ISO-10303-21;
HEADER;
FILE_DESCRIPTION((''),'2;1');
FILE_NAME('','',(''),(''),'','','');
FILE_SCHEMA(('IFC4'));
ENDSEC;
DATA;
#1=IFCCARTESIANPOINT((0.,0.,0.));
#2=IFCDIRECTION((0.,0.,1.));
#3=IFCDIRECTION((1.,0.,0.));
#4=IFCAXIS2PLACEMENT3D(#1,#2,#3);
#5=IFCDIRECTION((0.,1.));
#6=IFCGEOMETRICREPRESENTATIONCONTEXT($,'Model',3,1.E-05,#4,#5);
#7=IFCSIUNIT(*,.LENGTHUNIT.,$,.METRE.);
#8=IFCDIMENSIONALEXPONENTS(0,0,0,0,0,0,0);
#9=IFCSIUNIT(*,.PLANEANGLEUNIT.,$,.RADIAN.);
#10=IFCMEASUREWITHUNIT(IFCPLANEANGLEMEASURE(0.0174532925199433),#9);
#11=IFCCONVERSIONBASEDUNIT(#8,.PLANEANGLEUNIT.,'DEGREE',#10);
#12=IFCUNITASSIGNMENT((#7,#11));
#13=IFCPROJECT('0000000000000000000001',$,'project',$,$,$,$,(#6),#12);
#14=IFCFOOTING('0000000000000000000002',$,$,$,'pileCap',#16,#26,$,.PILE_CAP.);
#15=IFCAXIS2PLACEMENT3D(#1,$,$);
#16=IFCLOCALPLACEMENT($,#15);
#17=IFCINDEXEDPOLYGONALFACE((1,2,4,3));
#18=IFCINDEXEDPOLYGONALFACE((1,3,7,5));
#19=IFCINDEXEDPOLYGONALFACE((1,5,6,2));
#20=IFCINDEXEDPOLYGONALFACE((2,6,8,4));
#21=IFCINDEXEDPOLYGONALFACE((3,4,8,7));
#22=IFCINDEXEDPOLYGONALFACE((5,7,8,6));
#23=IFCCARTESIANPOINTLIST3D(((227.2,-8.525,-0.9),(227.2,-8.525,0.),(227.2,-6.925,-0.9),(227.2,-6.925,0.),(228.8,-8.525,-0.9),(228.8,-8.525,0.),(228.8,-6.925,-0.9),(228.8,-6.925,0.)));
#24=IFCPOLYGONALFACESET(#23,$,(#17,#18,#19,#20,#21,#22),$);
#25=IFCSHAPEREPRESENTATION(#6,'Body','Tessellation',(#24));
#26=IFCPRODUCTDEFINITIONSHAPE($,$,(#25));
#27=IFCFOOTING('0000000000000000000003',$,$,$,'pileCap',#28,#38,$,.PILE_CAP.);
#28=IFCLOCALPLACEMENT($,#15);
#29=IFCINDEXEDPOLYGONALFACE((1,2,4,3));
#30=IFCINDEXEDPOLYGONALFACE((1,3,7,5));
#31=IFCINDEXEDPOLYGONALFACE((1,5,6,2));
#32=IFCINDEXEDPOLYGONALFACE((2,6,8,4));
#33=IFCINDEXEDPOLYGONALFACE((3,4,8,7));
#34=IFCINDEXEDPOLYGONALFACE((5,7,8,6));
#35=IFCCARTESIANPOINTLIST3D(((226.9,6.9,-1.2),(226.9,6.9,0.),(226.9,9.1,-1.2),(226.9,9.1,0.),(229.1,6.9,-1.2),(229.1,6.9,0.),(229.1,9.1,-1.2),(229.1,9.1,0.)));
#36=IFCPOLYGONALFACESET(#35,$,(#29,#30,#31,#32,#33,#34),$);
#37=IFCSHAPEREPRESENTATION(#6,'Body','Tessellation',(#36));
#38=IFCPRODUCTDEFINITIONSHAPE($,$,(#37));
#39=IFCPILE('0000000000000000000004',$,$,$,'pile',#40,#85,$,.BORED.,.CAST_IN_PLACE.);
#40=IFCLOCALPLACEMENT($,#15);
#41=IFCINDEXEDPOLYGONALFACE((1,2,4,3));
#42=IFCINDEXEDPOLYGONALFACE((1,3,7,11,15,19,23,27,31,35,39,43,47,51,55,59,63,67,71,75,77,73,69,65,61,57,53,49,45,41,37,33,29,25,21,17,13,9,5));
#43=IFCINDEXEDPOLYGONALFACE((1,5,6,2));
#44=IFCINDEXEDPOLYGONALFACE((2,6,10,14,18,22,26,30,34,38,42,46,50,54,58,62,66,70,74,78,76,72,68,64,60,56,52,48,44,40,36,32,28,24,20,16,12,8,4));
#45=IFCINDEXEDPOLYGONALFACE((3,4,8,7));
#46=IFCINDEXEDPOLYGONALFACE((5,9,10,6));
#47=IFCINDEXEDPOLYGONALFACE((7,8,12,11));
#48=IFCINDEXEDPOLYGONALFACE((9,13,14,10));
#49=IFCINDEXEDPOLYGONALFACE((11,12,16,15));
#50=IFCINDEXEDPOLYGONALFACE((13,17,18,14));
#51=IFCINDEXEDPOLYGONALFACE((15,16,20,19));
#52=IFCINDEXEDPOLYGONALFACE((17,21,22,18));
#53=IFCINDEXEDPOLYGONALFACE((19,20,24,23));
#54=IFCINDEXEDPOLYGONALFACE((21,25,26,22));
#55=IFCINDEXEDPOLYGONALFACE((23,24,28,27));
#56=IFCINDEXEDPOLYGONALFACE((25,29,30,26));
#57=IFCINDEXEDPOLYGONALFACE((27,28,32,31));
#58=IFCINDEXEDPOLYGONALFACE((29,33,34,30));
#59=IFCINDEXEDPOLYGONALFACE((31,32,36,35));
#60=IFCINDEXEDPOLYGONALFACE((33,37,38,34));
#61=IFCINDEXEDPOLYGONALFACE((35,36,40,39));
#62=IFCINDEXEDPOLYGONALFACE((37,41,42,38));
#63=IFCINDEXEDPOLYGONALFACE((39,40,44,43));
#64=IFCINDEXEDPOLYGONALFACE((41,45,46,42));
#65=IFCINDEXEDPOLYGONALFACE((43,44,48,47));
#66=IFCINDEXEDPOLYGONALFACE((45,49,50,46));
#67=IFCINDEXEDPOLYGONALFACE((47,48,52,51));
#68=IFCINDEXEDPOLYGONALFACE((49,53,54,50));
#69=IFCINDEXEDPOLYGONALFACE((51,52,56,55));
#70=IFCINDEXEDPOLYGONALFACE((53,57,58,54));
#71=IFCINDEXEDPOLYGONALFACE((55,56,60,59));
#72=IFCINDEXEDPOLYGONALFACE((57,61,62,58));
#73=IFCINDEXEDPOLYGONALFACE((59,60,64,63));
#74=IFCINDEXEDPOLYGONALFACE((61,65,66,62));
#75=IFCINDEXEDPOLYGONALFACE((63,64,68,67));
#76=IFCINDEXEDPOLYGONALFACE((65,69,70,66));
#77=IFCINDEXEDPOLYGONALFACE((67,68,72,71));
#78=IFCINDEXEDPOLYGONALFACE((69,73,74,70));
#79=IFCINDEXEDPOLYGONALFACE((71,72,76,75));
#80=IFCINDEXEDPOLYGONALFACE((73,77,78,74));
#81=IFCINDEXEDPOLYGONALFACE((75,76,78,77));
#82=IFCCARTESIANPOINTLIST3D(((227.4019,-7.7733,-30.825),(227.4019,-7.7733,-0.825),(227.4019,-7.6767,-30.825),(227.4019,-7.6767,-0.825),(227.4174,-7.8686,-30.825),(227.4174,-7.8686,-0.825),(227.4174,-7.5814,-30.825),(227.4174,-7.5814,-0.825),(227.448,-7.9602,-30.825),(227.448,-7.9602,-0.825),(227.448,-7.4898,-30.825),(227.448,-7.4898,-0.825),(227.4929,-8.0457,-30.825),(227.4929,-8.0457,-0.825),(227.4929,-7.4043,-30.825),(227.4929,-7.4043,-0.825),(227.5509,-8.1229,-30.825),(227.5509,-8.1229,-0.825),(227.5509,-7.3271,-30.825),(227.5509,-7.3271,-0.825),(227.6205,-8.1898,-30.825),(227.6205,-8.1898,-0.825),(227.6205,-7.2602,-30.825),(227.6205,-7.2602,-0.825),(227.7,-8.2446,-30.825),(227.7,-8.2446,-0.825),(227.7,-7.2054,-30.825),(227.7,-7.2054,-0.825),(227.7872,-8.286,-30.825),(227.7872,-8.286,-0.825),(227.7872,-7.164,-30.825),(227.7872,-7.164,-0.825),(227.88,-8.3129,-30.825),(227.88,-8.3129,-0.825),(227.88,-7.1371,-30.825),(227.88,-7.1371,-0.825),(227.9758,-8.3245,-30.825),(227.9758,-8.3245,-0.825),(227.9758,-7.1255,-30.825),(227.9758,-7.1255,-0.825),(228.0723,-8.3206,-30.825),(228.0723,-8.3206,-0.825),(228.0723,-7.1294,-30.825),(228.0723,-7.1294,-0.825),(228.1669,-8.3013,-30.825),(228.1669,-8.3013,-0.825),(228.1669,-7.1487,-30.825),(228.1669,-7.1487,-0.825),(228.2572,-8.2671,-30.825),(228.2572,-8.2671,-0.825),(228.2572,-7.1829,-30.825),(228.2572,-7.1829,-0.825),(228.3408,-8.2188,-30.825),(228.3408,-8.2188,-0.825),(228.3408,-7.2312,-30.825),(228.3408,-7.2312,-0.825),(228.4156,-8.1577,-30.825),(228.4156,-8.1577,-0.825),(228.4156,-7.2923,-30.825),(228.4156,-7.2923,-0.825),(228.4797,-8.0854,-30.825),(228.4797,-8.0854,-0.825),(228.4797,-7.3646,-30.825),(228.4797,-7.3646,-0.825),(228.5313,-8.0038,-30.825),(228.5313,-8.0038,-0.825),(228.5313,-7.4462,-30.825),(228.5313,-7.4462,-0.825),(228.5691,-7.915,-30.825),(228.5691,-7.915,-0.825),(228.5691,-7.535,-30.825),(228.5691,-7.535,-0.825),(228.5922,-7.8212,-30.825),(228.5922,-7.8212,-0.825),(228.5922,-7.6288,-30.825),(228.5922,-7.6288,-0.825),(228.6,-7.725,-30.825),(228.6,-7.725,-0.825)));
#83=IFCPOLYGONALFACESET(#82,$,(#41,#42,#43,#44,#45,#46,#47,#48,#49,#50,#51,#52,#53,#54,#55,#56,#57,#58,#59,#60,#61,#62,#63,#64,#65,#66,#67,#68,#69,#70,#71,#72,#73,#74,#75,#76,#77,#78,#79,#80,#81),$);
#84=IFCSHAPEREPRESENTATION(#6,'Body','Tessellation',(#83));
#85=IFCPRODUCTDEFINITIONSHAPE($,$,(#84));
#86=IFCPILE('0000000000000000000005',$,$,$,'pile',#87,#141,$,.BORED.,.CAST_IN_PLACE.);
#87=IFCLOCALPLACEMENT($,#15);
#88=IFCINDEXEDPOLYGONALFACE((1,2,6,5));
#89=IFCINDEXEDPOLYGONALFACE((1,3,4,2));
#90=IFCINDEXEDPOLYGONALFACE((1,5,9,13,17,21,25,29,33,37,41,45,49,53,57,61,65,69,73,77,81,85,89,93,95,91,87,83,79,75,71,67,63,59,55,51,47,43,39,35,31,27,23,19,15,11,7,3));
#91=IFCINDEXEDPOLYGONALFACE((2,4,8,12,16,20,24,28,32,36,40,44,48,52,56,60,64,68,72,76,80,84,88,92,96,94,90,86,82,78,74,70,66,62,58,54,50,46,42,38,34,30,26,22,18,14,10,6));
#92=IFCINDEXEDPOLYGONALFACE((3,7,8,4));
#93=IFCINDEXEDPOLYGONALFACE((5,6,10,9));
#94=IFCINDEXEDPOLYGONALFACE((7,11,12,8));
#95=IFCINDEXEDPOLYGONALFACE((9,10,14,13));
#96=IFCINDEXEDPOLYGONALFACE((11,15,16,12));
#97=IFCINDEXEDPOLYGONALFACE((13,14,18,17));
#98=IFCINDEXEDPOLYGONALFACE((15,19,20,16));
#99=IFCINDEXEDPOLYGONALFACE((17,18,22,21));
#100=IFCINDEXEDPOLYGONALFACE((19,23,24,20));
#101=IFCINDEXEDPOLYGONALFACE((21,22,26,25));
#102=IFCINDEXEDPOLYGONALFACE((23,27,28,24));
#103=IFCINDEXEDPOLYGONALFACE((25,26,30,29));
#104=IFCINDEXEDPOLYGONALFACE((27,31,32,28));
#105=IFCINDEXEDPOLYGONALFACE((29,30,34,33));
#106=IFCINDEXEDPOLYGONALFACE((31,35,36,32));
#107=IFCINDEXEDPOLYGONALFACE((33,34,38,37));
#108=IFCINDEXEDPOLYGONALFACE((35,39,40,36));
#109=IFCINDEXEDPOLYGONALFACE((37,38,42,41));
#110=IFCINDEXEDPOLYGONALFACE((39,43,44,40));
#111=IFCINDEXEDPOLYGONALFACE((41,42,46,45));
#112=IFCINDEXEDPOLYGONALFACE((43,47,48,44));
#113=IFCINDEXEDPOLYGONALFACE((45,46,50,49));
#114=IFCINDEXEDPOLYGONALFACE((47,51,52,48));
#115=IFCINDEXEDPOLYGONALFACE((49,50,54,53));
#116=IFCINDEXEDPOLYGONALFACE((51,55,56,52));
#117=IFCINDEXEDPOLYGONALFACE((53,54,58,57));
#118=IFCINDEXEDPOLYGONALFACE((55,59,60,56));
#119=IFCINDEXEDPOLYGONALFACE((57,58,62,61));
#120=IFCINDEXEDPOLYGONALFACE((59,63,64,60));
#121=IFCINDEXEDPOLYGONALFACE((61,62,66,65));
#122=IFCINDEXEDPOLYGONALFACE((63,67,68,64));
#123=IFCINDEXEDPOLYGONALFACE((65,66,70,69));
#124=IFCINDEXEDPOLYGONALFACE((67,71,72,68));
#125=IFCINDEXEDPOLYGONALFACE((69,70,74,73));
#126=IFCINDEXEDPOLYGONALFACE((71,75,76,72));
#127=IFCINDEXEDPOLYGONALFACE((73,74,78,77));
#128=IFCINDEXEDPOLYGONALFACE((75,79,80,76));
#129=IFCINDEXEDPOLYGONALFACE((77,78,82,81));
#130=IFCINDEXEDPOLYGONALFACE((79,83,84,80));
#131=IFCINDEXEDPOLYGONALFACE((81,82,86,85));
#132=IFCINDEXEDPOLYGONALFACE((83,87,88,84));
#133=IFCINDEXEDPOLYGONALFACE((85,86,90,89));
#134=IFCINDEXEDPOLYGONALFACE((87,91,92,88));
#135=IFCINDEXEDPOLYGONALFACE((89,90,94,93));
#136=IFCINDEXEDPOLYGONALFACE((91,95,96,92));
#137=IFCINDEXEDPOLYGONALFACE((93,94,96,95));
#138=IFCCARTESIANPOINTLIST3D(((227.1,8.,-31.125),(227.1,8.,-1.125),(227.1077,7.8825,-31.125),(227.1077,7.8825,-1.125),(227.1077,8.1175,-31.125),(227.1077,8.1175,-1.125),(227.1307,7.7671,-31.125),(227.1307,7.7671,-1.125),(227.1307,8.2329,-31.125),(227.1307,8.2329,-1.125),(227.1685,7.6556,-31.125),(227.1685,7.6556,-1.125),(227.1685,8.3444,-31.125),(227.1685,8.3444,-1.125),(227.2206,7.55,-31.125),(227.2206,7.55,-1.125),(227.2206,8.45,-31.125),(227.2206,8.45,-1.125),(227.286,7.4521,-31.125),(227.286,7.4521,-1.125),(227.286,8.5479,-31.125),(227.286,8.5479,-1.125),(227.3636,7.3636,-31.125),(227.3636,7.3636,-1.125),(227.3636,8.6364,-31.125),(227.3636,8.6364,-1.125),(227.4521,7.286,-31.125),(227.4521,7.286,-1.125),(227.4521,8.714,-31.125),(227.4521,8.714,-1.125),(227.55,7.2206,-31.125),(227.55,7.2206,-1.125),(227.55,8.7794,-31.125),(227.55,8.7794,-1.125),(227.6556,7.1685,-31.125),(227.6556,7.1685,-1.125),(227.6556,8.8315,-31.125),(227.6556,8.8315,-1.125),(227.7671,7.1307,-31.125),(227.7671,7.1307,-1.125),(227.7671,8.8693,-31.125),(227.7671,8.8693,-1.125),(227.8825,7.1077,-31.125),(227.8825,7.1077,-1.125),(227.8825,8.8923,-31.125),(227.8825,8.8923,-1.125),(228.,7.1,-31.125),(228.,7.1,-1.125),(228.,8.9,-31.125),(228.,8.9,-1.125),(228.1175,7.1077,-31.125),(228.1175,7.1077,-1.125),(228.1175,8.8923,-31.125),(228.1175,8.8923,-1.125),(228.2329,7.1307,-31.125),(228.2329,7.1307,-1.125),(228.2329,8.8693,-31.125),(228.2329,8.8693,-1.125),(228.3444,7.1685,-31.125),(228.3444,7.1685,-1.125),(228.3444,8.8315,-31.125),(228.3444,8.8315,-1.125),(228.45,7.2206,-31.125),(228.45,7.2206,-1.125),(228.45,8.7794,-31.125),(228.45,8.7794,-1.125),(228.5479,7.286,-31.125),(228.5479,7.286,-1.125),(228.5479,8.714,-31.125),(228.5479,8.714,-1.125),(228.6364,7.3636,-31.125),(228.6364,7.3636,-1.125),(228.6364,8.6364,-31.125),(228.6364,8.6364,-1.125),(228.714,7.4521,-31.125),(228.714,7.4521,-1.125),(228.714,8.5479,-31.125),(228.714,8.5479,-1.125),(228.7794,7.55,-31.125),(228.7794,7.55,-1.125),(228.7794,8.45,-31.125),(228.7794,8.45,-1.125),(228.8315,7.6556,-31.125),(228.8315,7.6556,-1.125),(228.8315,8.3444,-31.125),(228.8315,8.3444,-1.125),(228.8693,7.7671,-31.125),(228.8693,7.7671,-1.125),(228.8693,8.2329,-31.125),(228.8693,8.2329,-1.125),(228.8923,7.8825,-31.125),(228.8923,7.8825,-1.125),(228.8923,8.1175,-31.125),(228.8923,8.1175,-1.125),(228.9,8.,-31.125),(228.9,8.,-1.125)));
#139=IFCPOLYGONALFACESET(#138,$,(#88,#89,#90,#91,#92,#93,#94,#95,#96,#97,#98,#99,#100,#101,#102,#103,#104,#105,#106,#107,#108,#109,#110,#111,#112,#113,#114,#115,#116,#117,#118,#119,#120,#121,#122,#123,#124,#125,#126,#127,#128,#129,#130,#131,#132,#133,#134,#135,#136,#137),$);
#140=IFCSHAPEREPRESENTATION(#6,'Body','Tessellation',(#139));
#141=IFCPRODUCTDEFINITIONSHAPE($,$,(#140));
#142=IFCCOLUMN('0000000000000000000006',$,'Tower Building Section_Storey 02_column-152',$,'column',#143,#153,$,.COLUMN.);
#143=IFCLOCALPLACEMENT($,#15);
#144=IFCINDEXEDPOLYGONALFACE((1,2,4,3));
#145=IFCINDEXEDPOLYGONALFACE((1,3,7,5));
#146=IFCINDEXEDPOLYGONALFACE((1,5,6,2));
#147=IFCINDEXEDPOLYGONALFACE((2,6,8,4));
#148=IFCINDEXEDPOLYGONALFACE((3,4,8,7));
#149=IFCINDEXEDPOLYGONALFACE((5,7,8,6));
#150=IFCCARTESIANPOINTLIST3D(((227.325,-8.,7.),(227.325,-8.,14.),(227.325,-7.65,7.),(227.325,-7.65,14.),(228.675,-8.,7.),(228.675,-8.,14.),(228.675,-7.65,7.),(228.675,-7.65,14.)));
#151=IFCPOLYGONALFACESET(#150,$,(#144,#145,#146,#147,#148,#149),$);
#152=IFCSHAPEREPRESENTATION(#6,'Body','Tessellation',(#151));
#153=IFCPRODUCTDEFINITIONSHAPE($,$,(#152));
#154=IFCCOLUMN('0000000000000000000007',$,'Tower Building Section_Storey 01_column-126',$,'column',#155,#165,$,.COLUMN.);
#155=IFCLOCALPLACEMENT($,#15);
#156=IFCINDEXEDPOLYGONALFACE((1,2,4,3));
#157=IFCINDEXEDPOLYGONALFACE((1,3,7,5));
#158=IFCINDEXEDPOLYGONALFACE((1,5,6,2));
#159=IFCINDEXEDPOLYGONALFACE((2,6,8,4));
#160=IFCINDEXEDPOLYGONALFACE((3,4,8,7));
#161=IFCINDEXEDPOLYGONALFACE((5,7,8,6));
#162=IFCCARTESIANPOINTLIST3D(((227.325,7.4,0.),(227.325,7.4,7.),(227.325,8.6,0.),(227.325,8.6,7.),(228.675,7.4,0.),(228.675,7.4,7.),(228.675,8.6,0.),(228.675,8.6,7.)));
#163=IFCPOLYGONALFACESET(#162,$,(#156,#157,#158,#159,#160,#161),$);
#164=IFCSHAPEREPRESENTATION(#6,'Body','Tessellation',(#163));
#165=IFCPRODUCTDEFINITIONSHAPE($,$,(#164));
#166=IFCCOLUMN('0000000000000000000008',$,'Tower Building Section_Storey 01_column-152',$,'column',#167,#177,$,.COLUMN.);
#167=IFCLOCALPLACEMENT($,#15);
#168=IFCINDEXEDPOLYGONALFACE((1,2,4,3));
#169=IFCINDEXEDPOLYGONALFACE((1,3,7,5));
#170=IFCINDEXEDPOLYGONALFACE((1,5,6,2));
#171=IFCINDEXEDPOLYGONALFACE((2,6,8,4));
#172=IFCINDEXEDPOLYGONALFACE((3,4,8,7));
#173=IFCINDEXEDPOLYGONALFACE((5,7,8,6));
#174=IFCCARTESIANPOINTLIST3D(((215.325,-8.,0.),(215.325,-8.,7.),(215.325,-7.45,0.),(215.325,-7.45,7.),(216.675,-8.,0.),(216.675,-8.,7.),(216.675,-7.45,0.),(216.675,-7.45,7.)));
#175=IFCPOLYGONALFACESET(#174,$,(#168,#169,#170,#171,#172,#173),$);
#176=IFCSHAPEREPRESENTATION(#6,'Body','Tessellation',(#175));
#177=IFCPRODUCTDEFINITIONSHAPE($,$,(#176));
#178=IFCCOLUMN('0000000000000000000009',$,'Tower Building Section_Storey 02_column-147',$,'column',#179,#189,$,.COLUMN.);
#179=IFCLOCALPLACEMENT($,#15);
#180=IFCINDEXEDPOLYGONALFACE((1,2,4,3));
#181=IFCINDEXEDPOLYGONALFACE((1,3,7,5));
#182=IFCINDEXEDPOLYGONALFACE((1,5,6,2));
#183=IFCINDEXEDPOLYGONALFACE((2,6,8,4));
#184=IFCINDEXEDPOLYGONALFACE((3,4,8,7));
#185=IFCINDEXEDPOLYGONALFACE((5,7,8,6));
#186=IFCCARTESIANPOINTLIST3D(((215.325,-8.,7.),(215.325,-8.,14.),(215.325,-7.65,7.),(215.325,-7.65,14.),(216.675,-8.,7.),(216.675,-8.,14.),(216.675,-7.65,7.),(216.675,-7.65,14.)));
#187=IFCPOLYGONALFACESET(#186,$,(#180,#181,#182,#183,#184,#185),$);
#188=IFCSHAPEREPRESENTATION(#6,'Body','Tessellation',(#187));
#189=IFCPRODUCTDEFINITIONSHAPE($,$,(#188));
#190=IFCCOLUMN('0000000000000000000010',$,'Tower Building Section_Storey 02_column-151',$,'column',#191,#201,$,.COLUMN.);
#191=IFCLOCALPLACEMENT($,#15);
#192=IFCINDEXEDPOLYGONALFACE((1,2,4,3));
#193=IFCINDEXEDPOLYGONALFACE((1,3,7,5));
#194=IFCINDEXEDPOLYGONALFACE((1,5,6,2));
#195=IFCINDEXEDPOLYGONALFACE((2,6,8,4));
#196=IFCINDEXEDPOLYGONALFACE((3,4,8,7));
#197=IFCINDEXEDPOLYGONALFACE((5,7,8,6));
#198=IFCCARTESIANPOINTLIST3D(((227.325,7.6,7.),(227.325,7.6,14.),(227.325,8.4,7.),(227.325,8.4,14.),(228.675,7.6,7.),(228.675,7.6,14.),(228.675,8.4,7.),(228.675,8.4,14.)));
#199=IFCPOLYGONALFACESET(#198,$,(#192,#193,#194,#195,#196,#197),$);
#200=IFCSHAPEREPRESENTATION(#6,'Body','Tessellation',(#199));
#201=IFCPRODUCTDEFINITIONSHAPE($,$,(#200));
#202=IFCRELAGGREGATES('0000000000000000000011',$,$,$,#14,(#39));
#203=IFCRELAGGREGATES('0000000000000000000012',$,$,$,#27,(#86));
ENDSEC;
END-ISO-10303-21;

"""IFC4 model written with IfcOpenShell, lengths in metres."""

from ifc_helpers import new_model, entity, si_unit, converted_unit, direction, frame, origin_with_axes, place, context, project, polyline, circle_curve, parameter, trimmed, segment, composite_curve, outline, extrude, element, aggregate, save


model = new_model("IFC4")

# Units and contexts
model_context = context("Model", 3, precision=1e-05, world=origin_with_axes(), true_north=direction((0.0, 1.0)))
ifc_project = project(units=[si_unit("LENGTHUNIT", "METRE"), converted_unit("PLANEANGLEUNIT", "DEGREE", entity("IfcPlaneAngleMeasure", 0.0174532925199433), si_unit("PLANEANGLEUNIT", "RADIAN"), dimensions=[0, 0, 0, 0, 0, 0, 0])], contexts=[model_context])

# Footings
placement_1 = place(None, origin_with_axes())
placement_2 = place(placement_1, origin_with_axes())
footing_1_placement = place(placement_2, frame((228.0, -7.725, -0.9), z_axis=(0.0, 0.0, 1.0), x_axis=(1.0, 0.0, 0.0)))
footing_1 = element("IfcFooting", 1, at=footing_1_placement, ObjectType="pileCap", PredefinedType="PILE_CAP", context=model_context, body=[
    extrude(outline(polyline([(0.8, -0.8, 0.0), (0.8, 0.8, 0.0), (-0.8, 0.8, 0.0), (-0.8, -0.8, 0.0), (0.8, -0.8, 0.0)])), origin_with_axes(), (0.0, 0.0, 1.0), 0.9),
])
footing_2_placement = place(placement_2, frame((228.0, 8.0, -1.2), z_axis=(0.0, 0.0, 1.0), x_axis=(1.0, 0.0, 0.0)))
footing_2 = element("IfcFooting", 2, at=footing_2_placement, ObjectType="pileCap", PredefinedType="PILE_CAP", context=model_context, body=[
    extrude(outline(polyline([(1.1, -1.1, 0.0), (1.1, 1.1, 0.0), (-1.1, 1.1, 0.0), (-1.1, -1.1, 0.0), (1.1, -1.1, 0.0)])), origin_with_axes(), (0.0, 0.0, 1.0), 1.2),
])

# Piles
pile_1_placement = place(footing_1_placement, frame((0.0, 0.0, -29.925), z_axis=(0.0, 0.0, 1.0), x_axis=(1.0, 0.0, 0.0)))
pile_1 = element("IfcPile", 3, at=pile_1_placement, ObjectType="pile", ConstructionType="CAST_IN_PLACE", PredefinedType="BORED", context=model_context, body=[
    extrude(outline(composite_curve([segment(trimmed(circle_curve(origin_with_axes(), 0.6), [parameter(0.0)], [parameter(360.0)], True, "PARAMETER"), True, "CONTINUOUS")], self_intersect=False)), origin_with_axes(), (0.0, 0.0, 1.0), 30.0),
])
aggregate(footing_1, [pile_1])
pile_2_placement = place(footing_2_placement, frame((0.0, 0.0, -29.925), z_axis=(0.0, 0.0, 1.0), x_axis=(1.0, 0.0, 0.0)))
pile_2 = element("IfcPile", 4, at=pile_2_placement, ObjectType="pile", ConstructionType="CAST_IN_PLACE", PredefinedType="BORED", context=model_context, body=[
    extrude(outline(composite_curve([segment(trimmed(circle_curve(origin_with_axes(), 0.9), [parameter(0.0)], [parameter(360.0)], True, "PARAMETER"), True, "CONTINUOUS")], self_intersect=False)), origin_with_axes(), (0.0, 0.0, 1.0), 30.0),
])
aggregate(footing_2, [pile_2])

# Columns
placement_3 = place(placement_1, frame((0.0, 0.0, 7.0), z_axis=(0.0, 0.0, 1.0), x_axis=(1.0, 0.0, 0.0)))
column_1_placement = place(placement_3, frame((228.0, -7.825, 0.0), z_axis=(0.0, 0.0, 1.0), x_axis=(1.0, 0.0, 0.0)))
element("IfcColumn", 5, at=column_1_placement, Name="Tower Building Section_Storey 02_column-152", ObjectType="column", PredefinedType="COLUMN", context=model_context, body=[
    extrude(outline(polyline([(-0.675, -0.175, 0.0), (0.675, -0.175, 0.0), (0.675, 0.175, 0.0), (-0.675, 0.175, 0.0), (-0.675, -0.175, 0.0)])), origin_with_axes(), (0.0, 0.0, 1.0), 7.0),
])
column_2_placement = place(placement_2, frame((228.0, 8.0, 0.0), z_axis=(0.0, 0.0, 1.0), x_axis=(1.0, 0.0, 0.0)))
element("IfcColumn", 6, at=column_2_placement, Name="Tower Building Section_Storey 01_column-126", ObjectType="column", PredefinedType="COLUMN", context=model_context, body=[
    extrude(outline(polyline([(-0.675, -0.6, 0.0), (0.675, -0.6, 0.0), (0.675, 0.6, 0.0), (-0.675, 0.6, 0.0), (-0.675, -0.6, 0.0)])), origin_with_axes(), (0.0, 0.0, 1.0), 7.0),
])
column_3_placement = place(placement_2, frame((216.0, -7.725, 0.0), z_axis=(0.0, 0.0, 1.0), x_axis=(1.0, 0.0, 0.0)))
element("IfcColumn", 7, at=column_3_placement, Name="Tower Building Section_Storey 01_column-152", ObjectType="column", PredefinedType="COLUMN", context=model_context, body=[
    extrude(outline(polyline([(-0.675, -0.275, 0.0), (0.675, -0.275, 0.0), (0.675, 0.275, 0.0), (-0.675, 0.275, 0.0), (-0.675, -0.275, 0.0)])), origin_with_axes(), (0.0, 0.0, 1.0), 7.0),
])
column_4_placement = place(placement_3, frame((216.0, -7.825, 0.0), z_axis=(0.0, 0.0, 1.0), x_axis=(1.0, 0.0, 0.0)))
element("IfcColumn", 8, at=column_4_placement, Name="Tower Building Section_Storey 02_column-147", ObjectType="column", PredefinedType="COLUMN", context=model_context, body=[
    extrude(outline(polyline([(-0.675, -0.175, 0.0), (0.675, -0.175, 0.0), (0.675, 0.175, 0.0), (-0.675, 0.175, 0.0), (-0.675, -0.175, 0.0)])), origin_with_axes(), (0.0, 0.0, 1.0), 7.0),
])
column_5_placement = place(placement_3, frame((228.0, 8.0, 0.0), z_axis=(0.0, 0.0, 1.0), x_axis=(1.0, 0.0, 0.0)))
element("IfcColumn", 9, at=column_5_placement, Name="Tower Building Section_Storey 02_column-151", ObjectType="column", PredefinedType="COLUMN", context=model_context, body=[
    extrude(outline(polyline([(-0.675, -0.4, 0.0), (0.675, -0.4, 0.0), (0.675, 0.4, 0.0), (-0.675, 0.4, 0.0), (-0.675, -0.4, 0.0)])), origin_with_axes(), (0.0, 0.0, 1.0), 7.0),
])

save(model, "model.ifc")
